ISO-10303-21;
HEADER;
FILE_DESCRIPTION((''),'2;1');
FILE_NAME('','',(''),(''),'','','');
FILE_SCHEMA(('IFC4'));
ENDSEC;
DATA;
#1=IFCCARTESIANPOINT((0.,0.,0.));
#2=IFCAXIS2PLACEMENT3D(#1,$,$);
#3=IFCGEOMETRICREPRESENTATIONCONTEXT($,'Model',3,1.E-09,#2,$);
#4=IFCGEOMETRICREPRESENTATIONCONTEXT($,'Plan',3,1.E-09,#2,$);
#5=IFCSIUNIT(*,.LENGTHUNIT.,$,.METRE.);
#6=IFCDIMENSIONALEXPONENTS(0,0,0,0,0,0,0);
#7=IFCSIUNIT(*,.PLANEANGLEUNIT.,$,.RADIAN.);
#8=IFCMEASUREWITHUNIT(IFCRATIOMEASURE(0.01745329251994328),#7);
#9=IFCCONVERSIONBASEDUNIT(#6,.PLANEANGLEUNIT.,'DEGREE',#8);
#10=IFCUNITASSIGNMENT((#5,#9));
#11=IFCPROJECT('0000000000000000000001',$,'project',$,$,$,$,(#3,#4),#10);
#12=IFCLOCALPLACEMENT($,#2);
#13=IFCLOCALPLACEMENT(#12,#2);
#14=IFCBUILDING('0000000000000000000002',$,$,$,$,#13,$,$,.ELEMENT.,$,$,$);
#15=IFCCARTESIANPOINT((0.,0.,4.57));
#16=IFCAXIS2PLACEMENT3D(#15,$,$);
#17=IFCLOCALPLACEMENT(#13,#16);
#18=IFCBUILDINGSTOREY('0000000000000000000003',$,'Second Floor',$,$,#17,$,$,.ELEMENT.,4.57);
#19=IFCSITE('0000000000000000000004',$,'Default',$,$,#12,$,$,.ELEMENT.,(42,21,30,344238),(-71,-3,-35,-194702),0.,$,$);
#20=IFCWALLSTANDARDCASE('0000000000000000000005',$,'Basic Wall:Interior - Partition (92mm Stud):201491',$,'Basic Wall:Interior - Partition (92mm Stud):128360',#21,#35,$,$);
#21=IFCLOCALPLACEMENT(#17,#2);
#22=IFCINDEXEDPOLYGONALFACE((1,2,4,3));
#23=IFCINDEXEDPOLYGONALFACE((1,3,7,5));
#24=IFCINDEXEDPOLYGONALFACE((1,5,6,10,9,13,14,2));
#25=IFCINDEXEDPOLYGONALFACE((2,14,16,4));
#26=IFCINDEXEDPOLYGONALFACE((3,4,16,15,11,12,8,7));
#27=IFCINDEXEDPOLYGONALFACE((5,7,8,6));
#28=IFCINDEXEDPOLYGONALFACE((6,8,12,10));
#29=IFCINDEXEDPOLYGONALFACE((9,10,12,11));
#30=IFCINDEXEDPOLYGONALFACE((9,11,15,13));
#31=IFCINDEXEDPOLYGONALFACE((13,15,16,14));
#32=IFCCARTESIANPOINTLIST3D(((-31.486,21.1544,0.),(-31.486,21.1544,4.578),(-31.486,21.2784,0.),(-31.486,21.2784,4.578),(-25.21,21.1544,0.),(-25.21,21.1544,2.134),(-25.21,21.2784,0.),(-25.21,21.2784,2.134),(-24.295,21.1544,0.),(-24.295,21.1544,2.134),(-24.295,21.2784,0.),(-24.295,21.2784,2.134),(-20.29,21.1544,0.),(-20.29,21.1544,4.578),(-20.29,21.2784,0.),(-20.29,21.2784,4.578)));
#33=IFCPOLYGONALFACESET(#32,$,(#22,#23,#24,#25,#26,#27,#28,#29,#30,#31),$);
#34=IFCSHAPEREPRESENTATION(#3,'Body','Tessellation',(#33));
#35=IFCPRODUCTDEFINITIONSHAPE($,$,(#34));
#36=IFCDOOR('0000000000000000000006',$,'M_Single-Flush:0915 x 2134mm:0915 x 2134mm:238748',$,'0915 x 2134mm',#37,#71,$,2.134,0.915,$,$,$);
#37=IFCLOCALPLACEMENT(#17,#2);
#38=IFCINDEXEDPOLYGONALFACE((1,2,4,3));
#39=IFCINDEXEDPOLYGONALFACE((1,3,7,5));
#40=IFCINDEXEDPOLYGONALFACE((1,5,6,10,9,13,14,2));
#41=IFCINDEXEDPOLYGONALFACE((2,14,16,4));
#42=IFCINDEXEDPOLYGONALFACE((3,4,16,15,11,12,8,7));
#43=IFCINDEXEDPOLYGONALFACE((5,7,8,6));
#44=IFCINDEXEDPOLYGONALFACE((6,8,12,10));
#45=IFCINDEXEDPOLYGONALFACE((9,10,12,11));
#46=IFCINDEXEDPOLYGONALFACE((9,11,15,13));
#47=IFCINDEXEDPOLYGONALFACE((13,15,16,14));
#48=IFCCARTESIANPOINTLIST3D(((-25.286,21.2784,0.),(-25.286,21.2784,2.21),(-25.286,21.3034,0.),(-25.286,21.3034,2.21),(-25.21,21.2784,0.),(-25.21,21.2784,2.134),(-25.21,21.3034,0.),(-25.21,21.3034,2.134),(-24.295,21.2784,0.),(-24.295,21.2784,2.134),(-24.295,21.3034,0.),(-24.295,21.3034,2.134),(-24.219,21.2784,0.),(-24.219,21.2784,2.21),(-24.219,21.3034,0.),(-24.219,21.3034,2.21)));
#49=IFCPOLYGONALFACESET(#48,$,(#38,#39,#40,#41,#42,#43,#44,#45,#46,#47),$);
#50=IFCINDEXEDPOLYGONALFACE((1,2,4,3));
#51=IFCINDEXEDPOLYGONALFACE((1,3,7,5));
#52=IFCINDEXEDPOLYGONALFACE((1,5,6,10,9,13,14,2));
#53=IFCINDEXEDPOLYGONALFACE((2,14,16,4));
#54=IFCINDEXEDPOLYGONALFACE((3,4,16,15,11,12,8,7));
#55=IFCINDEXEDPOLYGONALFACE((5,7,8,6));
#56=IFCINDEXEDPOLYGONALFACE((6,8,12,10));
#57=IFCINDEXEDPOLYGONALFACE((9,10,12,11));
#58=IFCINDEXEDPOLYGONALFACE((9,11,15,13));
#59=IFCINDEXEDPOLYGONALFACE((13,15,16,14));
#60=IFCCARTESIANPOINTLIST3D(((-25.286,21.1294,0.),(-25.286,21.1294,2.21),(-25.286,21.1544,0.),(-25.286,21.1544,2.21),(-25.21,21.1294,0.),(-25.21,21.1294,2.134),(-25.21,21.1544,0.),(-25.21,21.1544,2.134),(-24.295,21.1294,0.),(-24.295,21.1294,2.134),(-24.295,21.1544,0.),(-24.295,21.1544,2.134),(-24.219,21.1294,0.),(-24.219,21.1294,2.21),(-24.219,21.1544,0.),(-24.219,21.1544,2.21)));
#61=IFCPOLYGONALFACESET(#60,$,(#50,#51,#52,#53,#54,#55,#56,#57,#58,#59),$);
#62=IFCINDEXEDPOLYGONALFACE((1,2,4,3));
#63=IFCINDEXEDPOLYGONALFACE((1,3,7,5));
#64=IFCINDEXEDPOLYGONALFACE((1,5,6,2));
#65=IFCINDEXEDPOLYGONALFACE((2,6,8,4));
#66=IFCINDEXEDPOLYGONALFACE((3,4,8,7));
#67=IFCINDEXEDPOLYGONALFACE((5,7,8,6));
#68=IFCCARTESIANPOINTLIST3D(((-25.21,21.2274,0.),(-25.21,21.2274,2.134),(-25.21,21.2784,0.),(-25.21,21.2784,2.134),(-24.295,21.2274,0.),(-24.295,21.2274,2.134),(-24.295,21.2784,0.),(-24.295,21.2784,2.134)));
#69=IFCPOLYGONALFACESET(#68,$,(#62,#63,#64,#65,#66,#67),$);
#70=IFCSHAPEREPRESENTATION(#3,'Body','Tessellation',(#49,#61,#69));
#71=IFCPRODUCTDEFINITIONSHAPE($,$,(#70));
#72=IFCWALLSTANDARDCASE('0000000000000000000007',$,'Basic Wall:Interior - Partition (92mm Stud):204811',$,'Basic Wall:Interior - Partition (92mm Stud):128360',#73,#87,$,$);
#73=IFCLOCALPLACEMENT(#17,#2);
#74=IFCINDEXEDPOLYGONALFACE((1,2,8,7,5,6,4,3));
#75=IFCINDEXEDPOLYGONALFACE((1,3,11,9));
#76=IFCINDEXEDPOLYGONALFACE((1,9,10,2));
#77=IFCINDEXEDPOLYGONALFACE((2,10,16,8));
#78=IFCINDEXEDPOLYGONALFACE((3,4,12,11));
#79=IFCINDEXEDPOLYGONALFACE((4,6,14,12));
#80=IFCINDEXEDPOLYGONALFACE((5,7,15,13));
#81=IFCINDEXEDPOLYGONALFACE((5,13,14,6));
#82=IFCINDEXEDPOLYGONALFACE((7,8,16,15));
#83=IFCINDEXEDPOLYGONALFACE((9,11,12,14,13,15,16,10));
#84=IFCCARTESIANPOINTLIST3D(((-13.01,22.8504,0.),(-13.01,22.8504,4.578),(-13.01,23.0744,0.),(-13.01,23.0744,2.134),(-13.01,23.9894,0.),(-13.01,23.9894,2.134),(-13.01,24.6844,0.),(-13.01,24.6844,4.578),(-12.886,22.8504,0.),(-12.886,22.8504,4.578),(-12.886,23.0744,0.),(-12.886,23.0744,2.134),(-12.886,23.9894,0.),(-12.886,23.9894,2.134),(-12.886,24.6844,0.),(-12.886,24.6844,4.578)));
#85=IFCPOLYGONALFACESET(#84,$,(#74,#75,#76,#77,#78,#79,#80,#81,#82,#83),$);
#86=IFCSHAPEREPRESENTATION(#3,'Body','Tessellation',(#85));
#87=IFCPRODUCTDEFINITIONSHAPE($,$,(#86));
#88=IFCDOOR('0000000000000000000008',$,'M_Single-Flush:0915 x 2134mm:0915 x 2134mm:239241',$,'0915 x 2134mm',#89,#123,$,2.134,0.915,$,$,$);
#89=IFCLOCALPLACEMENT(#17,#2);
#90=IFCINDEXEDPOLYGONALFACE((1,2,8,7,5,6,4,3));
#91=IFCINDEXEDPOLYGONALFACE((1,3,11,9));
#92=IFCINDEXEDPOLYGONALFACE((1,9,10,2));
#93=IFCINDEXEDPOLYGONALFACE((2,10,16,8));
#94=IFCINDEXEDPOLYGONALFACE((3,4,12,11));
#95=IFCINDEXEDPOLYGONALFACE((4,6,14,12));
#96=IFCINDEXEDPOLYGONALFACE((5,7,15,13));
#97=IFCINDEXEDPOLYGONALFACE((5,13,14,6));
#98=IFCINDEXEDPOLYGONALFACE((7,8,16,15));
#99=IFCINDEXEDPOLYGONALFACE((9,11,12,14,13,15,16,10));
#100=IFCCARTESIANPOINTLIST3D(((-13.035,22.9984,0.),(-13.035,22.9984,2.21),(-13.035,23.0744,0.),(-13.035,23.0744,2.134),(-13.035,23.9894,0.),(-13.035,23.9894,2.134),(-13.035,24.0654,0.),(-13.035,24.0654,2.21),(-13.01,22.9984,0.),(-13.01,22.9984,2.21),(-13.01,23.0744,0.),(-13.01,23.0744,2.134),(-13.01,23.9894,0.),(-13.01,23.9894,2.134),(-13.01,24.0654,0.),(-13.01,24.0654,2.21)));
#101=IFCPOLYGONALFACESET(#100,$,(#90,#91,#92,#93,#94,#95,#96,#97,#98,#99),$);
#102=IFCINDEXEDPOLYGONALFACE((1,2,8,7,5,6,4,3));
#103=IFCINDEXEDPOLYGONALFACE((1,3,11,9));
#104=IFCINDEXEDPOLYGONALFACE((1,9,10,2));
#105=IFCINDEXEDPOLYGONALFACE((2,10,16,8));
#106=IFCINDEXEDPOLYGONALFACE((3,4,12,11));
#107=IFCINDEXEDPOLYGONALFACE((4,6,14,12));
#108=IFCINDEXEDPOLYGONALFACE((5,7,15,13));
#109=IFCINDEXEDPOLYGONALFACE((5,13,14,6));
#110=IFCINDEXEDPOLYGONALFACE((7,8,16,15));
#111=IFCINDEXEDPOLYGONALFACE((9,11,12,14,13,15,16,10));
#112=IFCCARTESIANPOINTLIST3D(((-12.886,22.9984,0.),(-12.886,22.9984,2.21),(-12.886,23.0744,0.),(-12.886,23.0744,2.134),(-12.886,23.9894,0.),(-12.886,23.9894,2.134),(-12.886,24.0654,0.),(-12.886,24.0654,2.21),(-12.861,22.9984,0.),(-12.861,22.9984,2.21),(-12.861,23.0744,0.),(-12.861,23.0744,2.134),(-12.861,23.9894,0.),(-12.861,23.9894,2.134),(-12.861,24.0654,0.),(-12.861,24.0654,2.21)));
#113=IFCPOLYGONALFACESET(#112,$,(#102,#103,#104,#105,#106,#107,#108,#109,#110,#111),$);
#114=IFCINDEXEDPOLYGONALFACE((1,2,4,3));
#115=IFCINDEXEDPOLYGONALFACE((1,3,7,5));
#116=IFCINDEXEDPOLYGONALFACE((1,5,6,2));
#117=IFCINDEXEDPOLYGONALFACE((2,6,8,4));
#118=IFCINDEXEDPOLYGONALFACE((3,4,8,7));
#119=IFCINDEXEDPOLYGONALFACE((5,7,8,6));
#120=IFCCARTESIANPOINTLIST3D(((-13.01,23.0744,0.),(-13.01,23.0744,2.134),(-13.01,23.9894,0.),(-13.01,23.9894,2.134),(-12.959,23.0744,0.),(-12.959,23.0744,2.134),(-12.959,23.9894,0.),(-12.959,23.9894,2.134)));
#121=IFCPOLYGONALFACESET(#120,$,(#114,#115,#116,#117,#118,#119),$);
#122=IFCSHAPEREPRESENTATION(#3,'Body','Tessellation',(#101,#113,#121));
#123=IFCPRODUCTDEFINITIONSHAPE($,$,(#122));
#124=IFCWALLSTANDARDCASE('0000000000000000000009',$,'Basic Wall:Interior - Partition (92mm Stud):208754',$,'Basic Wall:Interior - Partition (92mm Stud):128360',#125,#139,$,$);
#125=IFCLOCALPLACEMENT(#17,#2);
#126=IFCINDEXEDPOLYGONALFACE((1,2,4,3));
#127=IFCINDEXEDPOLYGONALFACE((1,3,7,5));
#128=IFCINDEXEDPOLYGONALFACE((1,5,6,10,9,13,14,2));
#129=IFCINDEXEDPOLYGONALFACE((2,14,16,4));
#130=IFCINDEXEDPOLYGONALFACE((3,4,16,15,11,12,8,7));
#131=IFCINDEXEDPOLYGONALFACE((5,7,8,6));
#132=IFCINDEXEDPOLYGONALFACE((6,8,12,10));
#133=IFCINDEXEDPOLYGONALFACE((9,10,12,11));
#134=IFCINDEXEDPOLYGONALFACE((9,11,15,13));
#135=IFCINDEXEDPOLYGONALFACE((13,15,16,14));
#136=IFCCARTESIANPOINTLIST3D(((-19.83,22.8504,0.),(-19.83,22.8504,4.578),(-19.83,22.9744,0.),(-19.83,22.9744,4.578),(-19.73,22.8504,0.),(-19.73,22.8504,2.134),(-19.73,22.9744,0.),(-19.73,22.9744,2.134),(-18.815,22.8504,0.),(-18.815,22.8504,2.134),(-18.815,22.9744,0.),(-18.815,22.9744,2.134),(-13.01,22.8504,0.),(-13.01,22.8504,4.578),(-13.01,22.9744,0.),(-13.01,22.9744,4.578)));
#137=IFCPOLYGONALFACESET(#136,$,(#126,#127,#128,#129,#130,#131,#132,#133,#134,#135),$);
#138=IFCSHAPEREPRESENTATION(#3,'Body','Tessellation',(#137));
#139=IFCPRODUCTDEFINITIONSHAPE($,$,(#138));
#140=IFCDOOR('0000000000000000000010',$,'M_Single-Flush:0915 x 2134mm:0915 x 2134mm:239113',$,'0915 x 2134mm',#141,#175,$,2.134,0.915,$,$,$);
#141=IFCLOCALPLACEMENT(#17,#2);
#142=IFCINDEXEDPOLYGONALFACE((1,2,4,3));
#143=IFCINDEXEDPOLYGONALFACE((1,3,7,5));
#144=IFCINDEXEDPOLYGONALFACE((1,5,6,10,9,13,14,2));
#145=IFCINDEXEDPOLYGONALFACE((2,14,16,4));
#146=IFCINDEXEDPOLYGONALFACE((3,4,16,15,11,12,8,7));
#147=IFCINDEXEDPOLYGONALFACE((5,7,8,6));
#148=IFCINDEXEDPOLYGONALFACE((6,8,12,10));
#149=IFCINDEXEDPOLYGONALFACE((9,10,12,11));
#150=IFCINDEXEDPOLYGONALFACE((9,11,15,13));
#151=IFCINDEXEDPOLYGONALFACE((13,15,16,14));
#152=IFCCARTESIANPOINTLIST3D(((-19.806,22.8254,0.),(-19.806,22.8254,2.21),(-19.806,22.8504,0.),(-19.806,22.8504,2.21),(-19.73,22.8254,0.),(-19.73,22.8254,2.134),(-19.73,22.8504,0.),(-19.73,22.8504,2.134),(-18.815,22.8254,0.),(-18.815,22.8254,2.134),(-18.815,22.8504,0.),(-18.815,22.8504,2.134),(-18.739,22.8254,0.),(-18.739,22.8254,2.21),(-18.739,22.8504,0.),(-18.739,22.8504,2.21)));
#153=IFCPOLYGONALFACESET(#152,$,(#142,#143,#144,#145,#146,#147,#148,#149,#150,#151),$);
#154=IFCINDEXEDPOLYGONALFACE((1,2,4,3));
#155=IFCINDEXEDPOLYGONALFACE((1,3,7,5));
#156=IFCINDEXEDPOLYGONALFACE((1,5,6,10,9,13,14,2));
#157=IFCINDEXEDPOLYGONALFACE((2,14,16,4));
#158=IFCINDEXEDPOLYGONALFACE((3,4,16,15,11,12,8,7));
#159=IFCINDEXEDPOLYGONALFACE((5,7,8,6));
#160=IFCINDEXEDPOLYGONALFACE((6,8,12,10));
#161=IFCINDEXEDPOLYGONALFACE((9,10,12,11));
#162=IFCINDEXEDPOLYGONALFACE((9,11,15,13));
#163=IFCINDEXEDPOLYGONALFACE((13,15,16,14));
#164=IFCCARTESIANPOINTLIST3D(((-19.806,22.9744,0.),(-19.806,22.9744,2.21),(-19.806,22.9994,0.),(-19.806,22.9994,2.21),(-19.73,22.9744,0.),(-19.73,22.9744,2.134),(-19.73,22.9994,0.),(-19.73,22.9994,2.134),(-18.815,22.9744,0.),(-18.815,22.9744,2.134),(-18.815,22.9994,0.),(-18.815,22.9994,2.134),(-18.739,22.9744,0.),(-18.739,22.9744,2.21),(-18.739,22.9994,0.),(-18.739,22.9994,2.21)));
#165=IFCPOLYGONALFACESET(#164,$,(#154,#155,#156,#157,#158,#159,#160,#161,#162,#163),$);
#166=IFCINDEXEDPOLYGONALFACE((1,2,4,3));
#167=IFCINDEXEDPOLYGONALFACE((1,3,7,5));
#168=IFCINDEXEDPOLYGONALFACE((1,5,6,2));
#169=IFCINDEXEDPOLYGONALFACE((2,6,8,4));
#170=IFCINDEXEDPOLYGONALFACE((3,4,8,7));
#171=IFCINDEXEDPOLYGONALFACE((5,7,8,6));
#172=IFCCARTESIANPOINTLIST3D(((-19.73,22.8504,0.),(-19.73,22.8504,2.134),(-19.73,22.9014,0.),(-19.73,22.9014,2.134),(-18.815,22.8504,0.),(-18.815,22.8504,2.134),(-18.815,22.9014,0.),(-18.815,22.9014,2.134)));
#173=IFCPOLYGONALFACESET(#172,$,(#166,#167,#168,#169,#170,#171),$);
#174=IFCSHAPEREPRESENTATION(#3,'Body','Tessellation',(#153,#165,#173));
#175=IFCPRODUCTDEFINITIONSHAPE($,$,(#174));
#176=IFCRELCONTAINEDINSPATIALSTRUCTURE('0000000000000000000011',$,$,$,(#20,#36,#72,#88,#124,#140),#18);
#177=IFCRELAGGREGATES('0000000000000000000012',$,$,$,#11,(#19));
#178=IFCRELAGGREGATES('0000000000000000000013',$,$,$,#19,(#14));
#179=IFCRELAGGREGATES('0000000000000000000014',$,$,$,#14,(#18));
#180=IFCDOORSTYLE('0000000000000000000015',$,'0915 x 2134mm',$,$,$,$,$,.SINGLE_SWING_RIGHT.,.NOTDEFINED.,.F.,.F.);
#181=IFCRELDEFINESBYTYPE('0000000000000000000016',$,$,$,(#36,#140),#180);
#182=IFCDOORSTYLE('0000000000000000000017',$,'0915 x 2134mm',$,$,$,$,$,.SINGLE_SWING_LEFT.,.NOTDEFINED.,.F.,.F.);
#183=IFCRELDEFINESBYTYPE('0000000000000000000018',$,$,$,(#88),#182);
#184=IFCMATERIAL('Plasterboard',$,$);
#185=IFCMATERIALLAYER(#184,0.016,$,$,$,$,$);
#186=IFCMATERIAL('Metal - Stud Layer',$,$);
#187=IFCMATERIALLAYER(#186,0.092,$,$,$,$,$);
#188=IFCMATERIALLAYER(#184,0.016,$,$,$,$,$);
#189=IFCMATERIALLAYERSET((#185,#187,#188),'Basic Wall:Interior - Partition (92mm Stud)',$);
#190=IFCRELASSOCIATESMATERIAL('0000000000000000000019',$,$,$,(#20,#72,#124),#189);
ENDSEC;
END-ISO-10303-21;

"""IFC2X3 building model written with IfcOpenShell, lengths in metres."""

from ifc_helpers import new_model, entity, si_unit, converted_unit, frame, frame_2d, origin, origin_2d_with_axis, place, context, project, spatial, polyline, rectangle, outline, extrude, source, transform, mapped, material, layer, layer_set, layer_usage, type_object, type_shapes, element, fill, save


model = new_model("IFC2X3")

# Units and contexts
model_context = context("Model", 3, precision=1e-09, world=origin())
plan_context = context("Plan", 3, precision=1e-09, world=origin())
ifc_project = project(units=[si_unit("LENGTHUNIT", "METRE"), converted_unit("PLANEANGLEUNIT", "DEGREE", entity("IfcRatioMeasure", 0.01745329251994328), si_unit("PLANEANGLEUNIT", "RADIAN"), dimensions=[0, 0, 0, 0, 0, 0, 0])], contexts=[model_context, plan_context])

# Site, building, storey
site_placement = place(None, origin())
site = spatial("IfcSite", under=ifc_project, at=site_placement, Name="Default", CompositionType="ELEMENT", RefLatitude=(42, 21, 30, 344238), RefLongitude=(-71, -3, -35, -194702), RefElevation=0.0)
building_placement = place(site_placement, origin())
building = spatial("IfcBuilding", under=site, at=building_placement, CompositionType="ELEMENT")
storey_placement = place(building_placement, frame((0.0, 0.0, 4.57)))
storey = spatial("IfcBuildingStorey", under=building, at=storey_placement, Name="Second Floor", CompositionType="ELEMENT", Elevation=4.57)

# Walls, openings, doors
ifc_material_1 = material(Name="Plasterboard")
ifc_layer_1 = layer(ifc_material_1, 0.016)
ifc_material_2 = material(Name="Metal - Stud Layer")
ifc_layer_2 = layer(ifc_material_2, 0.092)
ifc_layer_3 = layer(ifc_material_1, 0.016)
ifc_layer_set_1 = layer_set([ifc_layer_1, ifc_layer_2, ifc_layer_3], Name="Basic Wall:Interior - Partition (92mm Stud)")
ifc_layer_usage_1 = layer_usage(ifc_layer_set_1, "AXIS2", "NEGATIVE", 0.062)
wall_1_placement = place(storey_placement, frame((-20.29, 21.2164, 0.0), z_axis=(0.0, 0.0, 1.0), x_axis=(-1.0, 0.0, 0.0)))
wall_1 = element("IfcWallStandardCase", 1, at=wall_1_placement, inside=storey, material=ifc_layer_usage_1, Name="Basic Wall:Interior - Partition (92mm Stud):201491", ObjectType="Basic Wall:Interior - Partition (92mm Stud):128360", context=model_context, shape_type="SweptSolid", body=[
    extrude(rectangle(XDim=11.196, YDim=0.124, at=frame_2d((5.598, 0.0), x_axis=(-1.0, 0.0))), origin(), (0.0, 0.0, 1.0), 4.578),
])
opening_1_placement = place(wall_1_placement, frame((4.92, 0.062, 0.0)))
opening_1 = element("IfcOpeningElement", 2, at=opening_1_placement, cuts=wall_1, ObjectType="Opening", context=model_context, shape_type="SweptSolid", body=[
    extrude(rectangle(XDim=0.915, YDim=2.134, at=frame_2d((1.067, 0.4575), x_axis=(0.0, 1.0))), frame((0.0, 0.0, 0.0), z_axis=(0.0, -1.0, 0.0), x_axis=(0.0, 0.0, 1.0)), (0.0, 0.0, 1.0), 0.124),
])
door_style_1 = type_object("IfcDoorStyle", Name="0915 x 2134mm", ConstructionType="NOTDEFINED", OperationType="SINGLE_SWING_RIGHT", ParameterTakesPrecedence=False, Sizeable=False)
shared_shape_1 = source(origin(), model_context, "Body", "SweptSolid", [
    extrude(outline(polyline([(-0.5335, -1.124), (0.5335, -1.124), (0.5335, 1.086), (0.4575, 1.086), (0.4575, -1.048), (-0.4575, -1.048), (-0.4575, 1.086), (-0.5335, 1.086), (-0.5335, -1.124)])), frame((0.4575, 0.124, 1.086), z_axis=(0.0, 1.0, 0.0), x_axis=(1.0, 0.0, 0.0)), (0.0, 0.0, 1.0), 0.025),
    extrude(outline(polyline([(-1.124, -0.5335), (1.086, -0.5335), (1.086, -0.4575), (-1.048, -0.4575), (-1.048, 0.4575), (1.086, 0.4575), (1.086, 0.5335), (-1.124, 0.5335), (-1.124, -0.5335)])), frame((0.4575, -0.025, 1.086), z_axis=(0.0, 1.0, 0.0), x_axis=(0.0, 0.0, -1.0)), (0.0, 0.0, 1.0), 0.025),
    extrude(rectangle(XDim=0.051, YDim=0.915, at=origin_2d_with_axis()), frame((0.4575, 0.0985, 0.0), z_axis=(0.0, 0.0, 1.0), x_axis=(0.0, 1.0, 0.0)), (0.0, 0.0, 1.0), 2.134),
])
type_shapes(door_style_1, [shared_shape_1])
door_1_placement = place(opening_1_placement, frame((0.0, 0.0, 0.0), z_axis=(0.0, 0.0, 1.0), x_axis=(-1.0, 0.0, 0.0)))
door_1 = element("IfcDoor", 3, at=door_1_placement, inside=storey, type_object=door_style_1, Name="M_Single-Flush:0915 x 2134mm:0915 x 2134mm:238748", ObjectType="0915 x 2134mm", OverallHeight=2.134, OverallWidth=0.915, context=model_context, shape_type="MappedRepresentation", body=[
    mapped(shared_shape_1, transform((0.0, 0.0, 0.0), scale=1.0)),
])
fill(opening_1, door_1)
ifc_layer_usage_2 = layer_usage(ifc_layer_set_1, "AXIS2", "NEGATIVE", 0.062)
wall_2_placement = place(storey_placement, frame((-12.948, 22.8504, 0.0), z_axis=(0.0, 0.0, 1.0), x_axis=(0.0, 1.0, 0.0)))
wall_2 = element("IfcWallStandardCase", 4, at=wall_2_placement, inside=storey, material=ifc_layer_usage_2, Name="Basic Wall:Interior - Partition (92mm Stud):204811", ObjectType="Basic Wall:Interior - Partition (92mm Stud):128360", context=model_context, shape_type="SweptSolid", body=[
    extrude(rectangle(XDim=1.834, YDim=0.124, at=frame_2d((0.917, 0.0), x_axis=(-1.0, 0.0))), origin(), (0.0, 0.0, 1.0), 4.578),
])
opening_2_placement = place(wall_2_placement, frame((0.224, -0.062, 0.0)))
opening_2 = element("IfcOpeningElement", 5, at=opening_2_placement, cuts=wall_2, ObjectType="Opening", context=model_context, shape_type="SweptSolid", body=[
    extrude(rectangle(XDim=0.915, YDim=2.134, at=frame_2d((1.067, 0.4575), x_axis=(0.0, -1.0))), frame((0.0, 0.0, 0.0), z_axis=(0.0, 1.0, 0.0), x_axis=(0.0, 0.0, 1.0)), (0.0, 0.0, 1.0), 0.124),
])
door_style_2 = type_object("IfcDoorStyle", Name="0915 x 2134mm", ConstructionType="NOTDEFINED", OperationType="SINGLE_SWING_LEFT", ParameterTakesPrecedence=False, Sizeable=False)
shared_shape_2 = source(origin(), model_context, "Body", "SweptSolid", [
    extrude(outline(polyline([(-0.5335, -1.124), (0.5335, -1.124), (0.5335, 1.086), (0.4575, 1.086), (0.4575, -1.048), (-0.4575, -1.048), (-0.4575, 1.086), (-0.5335, 1.086), (-0.5335, -1.124)])), frame((0.4575, 0.149, 1.086), z_axis=(0.0, -1.0, 0.0), x_axis=(-1.0, 0.0, 0.0)), (0.0, 0.0, 1.0), 0.025),
    extrude(outline(polyline([(-1.124, -0.5335), (1.086, -0.5335), (1.086, -0.4575), (-1.048, -0.4575), (-1.048, 0.4575), (1.086, 0.4575), (1.086, 0.5335), (-1.124, 0.5335), (-1.124, -0.5335)])), frame((0.4575, 0.0, 1.086), z_axis=(0.0, -1.0, 0.0), x_axis=(0.0, 0.0, -1.0)), (0.0, 0.0, 1.0), 0.025),
    extrude(rectangle(XDim=0.915, YDim=0.051, at=origin_2d_with_axis()), frame((0.4575, 0.0985, 0.0)), (0.0, 0.0, 1.0), 2.134),
])
type_shapes(door_style_2, [shared_shape_2])
door_2_placement = place(opening_2_placement, origin())
door_2 = element("IfcDoor", 6, at=door_2_placement, inside=storey, type_object=door_style_2, Name="M_Single-Flush:0915 x 2134mm:0915 x 2134mm:239241", ObjectType="0915 x 2134mm", OverallHeight=2.134, OverallWidth=0.915, context=model_context, shape_type="MappedRepresentation", body=[
    mapped(shared_shape_2, transform((0.0, 0.0, 0.0), scale=1.0)),
])
fill(opening_2, door_2)
ifc_layer_usage_3 = layer_usage(ifc_layer_set_1, "AXIS2", "NEGATIVE", 0.062)
wall_3_placement = place(storey_placement, frame((-13.01, 22.9124, 0.0), z_axis=(0.0, 0.0, 1.0), x_axis=(-1.0, 0.0, 0.0)))
wall_3 = element("IfcWallStandardCase", 7, at=wall_3_placement, inside=storey, material=ifc_layer_usage_3, Name="Basic Wall:Interior - Partition (92mm Stud):208754", ObjectType="Basic Wall:Interior - Partition (92mm Stud):128360", context=model_context, shape_type="SweptSolid", body=[
    extrude(rectangle(XDim=6.82, YDim=0.124, at=frame_2d((3.41, 0.0), x_axis=(-1.0, 0.0))), origin(), (0.0, 0.0, 1.0), 4.578),
])
opening_3_placement = place(wall_3_placement, frame((5.805, -0.062, 0.0)))
opening_3 = element("IfcOpeningElement", 8, at=opening_3_placement, cuts=wall_3, ObjectType="Opening", context=model_context, shape_type="SweptSolid", body=[
    extrude(rectangle(XDim=0.915, YDim=2.134, at=frame_2d((1.067, 0.4575), x_axis=(0.0, 1.0))), frame((0.0, 0.0, 0.0), z_axis=(0.0, 1.0, 0.0), x_axis=(0.0, 0.0, 1.0)), (0.0, 0.0, 1.0), 0.124),
])
door_3_placement = place(opening_3_placement, origin())
door_3 = element("IfcDoor", 9, at=door_3_placement, inside=storey, type_object=door_style_1, Name="M_Single-Flush:0915 x 2134mm:0915 x 2134mm:239113", ObjectType="0915 x 2134mm", OverallHeight=2.134, OverallWidth=0.915, context=model_context, shape_type="MappedRepresentation", body=[
    mapped(shared_shape_1, transform((0.0, 0.0, 0.0), scale=1.0)),
])
fill(opening_3, door_3)

save(model, "model.ifc")
